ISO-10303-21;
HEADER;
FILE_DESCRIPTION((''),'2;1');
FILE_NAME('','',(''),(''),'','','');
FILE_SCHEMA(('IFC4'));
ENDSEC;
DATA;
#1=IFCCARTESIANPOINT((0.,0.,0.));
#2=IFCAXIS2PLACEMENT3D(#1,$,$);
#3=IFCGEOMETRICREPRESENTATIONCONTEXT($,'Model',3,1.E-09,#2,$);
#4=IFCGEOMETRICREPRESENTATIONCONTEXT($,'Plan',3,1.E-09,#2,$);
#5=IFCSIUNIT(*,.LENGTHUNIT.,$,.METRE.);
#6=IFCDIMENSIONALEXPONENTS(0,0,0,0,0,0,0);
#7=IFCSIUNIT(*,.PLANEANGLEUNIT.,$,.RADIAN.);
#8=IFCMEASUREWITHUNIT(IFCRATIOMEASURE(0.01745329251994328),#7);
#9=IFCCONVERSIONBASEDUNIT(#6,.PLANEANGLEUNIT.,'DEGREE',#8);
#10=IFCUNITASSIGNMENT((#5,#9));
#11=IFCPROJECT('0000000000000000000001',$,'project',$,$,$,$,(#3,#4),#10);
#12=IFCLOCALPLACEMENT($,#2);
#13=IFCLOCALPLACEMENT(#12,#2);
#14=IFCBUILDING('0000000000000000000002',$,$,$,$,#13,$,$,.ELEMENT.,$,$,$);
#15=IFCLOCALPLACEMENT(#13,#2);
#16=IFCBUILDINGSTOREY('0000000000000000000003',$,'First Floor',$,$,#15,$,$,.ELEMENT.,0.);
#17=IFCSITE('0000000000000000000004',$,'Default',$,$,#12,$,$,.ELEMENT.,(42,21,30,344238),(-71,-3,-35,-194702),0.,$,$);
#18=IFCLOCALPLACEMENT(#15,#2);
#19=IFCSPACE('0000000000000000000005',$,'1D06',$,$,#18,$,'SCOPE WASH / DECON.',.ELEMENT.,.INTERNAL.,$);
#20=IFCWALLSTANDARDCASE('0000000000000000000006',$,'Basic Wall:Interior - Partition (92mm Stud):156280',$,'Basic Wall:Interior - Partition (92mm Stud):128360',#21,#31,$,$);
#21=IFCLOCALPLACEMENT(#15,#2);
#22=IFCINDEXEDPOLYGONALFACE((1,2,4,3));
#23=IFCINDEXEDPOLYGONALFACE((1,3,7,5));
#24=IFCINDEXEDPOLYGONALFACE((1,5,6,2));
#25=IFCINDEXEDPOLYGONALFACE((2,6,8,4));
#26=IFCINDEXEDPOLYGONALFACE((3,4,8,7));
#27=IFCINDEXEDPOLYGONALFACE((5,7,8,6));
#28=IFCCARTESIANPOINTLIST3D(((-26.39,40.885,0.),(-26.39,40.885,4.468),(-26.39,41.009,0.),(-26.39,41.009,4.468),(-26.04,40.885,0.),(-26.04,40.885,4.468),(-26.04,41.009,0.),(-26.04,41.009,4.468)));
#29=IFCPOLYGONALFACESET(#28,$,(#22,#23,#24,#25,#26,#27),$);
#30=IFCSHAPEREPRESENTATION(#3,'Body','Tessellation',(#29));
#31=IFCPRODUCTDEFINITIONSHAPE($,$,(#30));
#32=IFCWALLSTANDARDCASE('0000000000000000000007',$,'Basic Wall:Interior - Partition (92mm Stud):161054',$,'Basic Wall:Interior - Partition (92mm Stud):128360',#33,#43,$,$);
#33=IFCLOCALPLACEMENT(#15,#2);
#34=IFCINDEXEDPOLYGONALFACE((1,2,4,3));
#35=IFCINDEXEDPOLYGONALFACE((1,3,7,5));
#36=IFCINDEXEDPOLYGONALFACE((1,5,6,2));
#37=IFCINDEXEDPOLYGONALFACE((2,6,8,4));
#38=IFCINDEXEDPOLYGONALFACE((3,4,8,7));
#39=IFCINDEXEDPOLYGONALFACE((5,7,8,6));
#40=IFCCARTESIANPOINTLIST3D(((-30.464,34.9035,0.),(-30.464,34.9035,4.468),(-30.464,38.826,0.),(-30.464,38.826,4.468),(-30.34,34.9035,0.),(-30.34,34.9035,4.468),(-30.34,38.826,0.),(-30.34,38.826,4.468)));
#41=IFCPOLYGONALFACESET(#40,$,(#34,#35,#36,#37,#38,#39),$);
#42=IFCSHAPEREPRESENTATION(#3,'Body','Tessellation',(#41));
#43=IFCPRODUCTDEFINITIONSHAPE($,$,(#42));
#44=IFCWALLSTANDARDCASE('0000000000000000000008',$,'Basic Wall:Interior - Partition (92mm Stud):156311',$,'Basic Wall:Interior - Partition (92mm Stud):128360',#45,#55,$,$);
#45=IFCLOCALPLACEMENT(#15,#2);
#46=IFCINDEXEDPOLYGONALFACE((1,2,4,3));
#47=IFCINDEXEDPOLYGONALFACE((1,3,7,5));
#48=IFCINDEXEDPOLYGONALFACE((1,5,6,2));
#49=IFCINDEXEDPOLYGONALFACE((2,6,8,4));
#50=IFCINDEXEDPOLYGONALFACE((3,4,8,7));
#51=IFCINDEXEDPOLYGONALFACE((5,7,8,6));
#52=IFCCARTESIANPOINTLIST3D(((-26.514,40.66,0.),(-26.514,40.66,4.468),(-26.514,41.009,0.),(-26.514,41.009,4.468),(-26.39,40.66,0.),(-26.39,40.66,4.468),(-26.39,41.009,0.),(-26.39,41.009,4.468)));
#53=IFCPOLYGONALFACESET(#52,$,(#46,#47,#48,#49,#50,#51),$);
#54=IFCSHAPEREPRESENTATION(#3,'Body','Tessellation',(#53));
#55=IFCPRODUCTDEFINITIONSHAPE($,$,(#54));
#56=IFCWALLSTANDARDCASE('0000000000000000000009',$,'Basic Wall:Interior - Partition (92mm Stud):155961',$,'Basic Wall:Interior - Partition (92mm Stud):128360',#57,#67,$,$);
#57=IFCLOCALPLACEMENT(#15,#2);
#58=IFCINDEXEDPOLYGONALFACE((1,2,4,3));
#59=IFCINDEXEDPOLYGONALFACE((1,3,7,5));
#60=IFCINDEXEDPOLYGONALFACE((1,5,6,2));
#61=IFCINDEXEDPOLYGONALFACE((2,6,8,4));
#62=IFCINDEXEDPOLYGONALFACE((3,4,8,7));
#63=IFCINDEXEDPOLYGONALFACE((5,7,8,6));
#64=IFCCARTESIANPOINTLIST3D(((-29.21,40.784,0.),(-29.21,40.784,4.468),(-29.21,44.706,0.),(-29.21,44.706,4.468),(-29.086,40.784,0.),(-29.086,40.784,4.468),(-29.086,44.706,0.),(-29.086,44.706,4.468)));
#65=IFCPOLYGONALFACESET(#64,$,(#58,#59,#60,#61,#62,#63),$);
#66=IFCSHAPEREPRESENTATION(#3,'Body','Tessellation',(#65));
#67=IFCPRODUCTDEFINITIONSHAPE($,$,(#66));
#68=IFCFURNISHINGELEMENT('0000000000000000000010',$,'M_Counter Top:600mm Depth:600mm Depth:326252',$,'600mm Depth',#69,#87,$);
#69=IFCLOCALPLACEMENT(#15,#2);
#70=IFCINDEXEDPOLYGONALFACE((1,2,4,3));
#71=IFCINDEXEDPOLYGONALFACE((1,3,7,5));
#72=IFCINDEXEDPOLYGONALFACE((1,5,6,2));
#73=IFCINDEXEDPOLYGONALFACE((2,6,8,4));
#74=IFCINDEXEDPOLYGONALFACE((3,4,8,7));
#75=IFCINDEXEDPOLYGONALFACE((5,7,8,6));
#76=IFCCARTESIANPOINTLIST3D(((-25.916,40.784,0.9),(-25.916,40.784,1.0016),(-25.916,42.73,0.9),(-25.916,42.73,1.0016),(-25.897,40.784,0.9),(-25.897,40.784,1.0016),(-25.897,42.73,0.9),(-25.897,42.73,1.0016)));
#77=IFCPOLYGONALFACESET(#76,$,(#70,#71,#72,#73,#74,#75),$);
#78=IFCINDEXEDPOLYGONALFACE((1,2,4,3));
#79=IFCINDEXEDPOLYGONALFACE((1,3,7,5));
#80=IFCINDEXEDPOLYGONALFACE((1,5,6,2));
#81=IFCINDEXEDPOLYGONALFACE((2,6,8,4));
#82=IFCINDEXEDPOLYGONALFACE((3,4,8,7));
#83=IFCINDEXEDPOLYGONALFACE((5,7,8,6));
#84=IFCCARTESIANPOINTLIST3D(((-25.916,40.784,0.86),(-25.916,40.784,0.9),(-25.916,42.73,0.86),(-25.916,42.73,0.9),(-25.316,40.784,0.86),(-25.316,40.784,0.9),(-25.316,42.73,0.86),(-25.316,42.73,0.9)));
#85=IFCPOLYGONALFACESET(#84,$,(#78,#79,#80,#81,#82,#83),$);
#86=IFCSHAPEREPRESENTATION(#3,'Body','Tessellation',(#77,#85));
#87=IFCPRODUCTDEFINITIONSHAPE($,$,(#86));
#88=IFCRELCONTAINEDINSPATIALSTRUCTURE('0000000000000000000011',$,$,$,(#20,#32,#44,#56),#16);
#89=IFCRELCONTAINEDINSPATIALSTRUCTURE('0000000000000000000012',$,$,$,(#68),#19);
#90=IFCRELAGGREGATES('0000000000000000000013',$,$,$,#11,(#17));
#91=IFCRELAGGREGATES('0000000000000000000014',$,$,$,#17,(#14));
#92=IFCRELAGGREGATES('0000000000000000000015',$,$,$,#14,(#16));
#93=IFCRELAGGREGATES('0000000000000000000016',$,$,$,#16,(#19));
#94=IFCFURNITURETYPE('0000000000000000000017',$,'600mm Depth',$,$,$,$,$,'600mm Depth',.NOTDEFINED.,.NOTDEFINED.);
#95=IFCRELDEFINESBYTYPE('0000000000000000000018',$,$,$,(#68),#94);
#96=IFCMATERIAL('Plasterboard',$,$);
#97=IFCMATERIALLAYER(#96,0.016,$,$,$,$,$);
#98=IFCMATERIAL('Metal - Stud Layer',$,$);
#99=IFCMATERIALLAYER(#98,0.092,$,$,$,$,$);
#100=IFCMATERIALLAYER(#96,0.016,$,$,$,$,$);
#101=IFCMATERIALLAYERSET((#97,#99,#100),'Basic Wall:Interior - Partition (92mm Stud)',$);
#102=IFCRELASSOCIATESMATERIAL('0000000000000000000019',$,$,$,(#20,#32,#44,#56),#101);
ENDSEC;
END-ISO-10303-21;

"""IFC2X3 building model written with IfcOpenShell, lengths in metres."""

from ifc_helpers import new_model, entity, si_unit, converted_unit, frame, frame_2d, origin, origin_2d_with_axis, place, context, project, spatial, rectangle, extrude, source, transform, mapped, material, layer, layer_set, layer_usage, type_object, type_shapes, element, save


model = new_model("IFC2X3")

# Units and contexts
model_context = context("Model", 3, precision=1e-09, world=origin())
plan_context = context("Plan", 3, precision=1e-09, world=origin())
ifc_project = project(units=[si_unit("LENGTHUNIT", "METRE"), converted_unit("PLANEANGLEUNIT", "DEGREE", entity("IfcRatioMeasure", 0.01745329251994328), si_unit("PLANEANGLEUNIT", "RADIAN"), dimensions=[0, 0, 0, 0, 0, 0, 0])], contexts=[model_context, plan_context])

# Site, building, storey
site_placement = place(None, origin())
site = spatial("IfcSite", under=ifc_project, at=site_placement, Name="Default", CompositionType="ELEMENT", RefLatitude=(42, 21, 30, 344238), RefLongitude=(-71, -3, -35, -194702), RefElevation=0.0)
building_placement = place(site_placement, origin())
building = spatial("IfcBuilding", under=site, at=building_placement, CompositionType="ELEMENT")
storey_placement = place(building_placement, origin())
storey = spatial("IfcBuildingStorey", under=building, at=storey_placement, Name="First Floor", CompositionType="ELEMENT", Elevation=0.0)

# Shared definitions
ifc_material_1 = material(Name="Plasterboard")
ifc_layer_1 = layer(ifc_material_1, 0.016)
ifc_material_2 = material(Name="Metal - Stud Layer")
ifc_layer_2 = layer(ifc_material_2, 0.092)
ifc_layer_3 = layer(ifc_material_1, 0.016)
ifc_layer_set_1 = layer_set([ifc_layer_1, ifc_layer_2, ifc_layer_3], Name="Basic Wall:Interior - Partition (92mm Stud)")
ifc_layer_usage_1 = layer_usage(ifc_layer_set_1, "AXIS2", "NEGATIVE", 0.062)

# Walls
wall_1_placement = place(storey_placement, frame((-26.04, 40.947, 0.0), z_axis=(0.0, 0.0, 1.0), x_axis=(-1.0, 0.0, 0.0)))
element("IfcWallStandardCase", 1, at=wall_1_placement, inside=storey, material=ifc_layer_usage_1, Name="Basic Wall:Interior - Partition (92mm Stud):156280", ObjectType="Basic Wall:Interior - Partition (92mm Stud):128360", context=model_context, shape_type="SweptSolid", body=[
    extrude(rectangle(XDim=0.35, YDim=0.124, at=frame_2d((0.175, 0.0), x_axis=(-1.0, 0.0))), origin(), (0.0, 0.0, 1.0), 4.468),
])
wall_2_placement = place(storey_placement, frame((-30.402, 38.826, 0.0), z_axis=(0.0, 0.0, 1.0), x_axis=(0.0, -1.0, 0.0)))
element("IfcWallStandardCase", 2, at=wall_2_placement, inside=storey, material=ifc_layer_usage_1, Name="Basic Wall:Interior - Partition (92mm Stud):161054", ObjectType="Basic Wall:Interior - Partition (92mm Stud):128360", context=model_context, shape_type="SweptSolid", body=[
    extrude(rectangle(XDim=3.9225, YDim=0.124, at=frame_2d((1.9612, 0.0), x_axis=(-1.0, 0.0))), origin(), (0.0, 0.0, 1.0), 4.468),
])
wall_3_placement = place(storey_placement, frame((-26.452, 41.009, 0.0), z_axis=(0.0, 0.0, 1.0), x_axis=(0.0, -1.0, 0.0)))
element("IfcWallStandardCase", 3, at=wall_3_placement, inside=storey, material=ifc_layer_usage_1, Name="Basic Wall:Interior - Partition (92mm Stud):156311", ObjectType="Basic Wall:Interior - Partition (92mm Stud):128360", context=model_context, shape_type="SweptSolid", body=[
    extrude(rectangle(XDim=0.349, YDim=0.124, at=frame_2d((0.1745, 0.0), x_axis=(-1.0, 0.0))), origin(), (0.0, 0.0, 1.0), 4.468),
])
wall_4_placement = place(storey_placement, frame((-29.148, 40.784, 0.0), z_axis=(0.0, 0.0, 1.0), x_axis=(0.0, 1.0, 0.0)))
element("IfcWallStandardCase", 4, at=wall_4_placement, inside=storey, material=ifc_layer_usage_1, Name="Basic Wall:Interior - Partition (92mm Stud):155961", ObjectType="Basic Wall:Interior - Partition (92mm Stud):128360", context=model_context, shape_type="SweptSolid", body=[
    extrude(rectangle(XDim=3.922, YDim=0.124, at=frame_2d((1.961, 0.0), x_axis=(-1.0, 0.0))), origin(), (0.0, 0.0, 1.0), 4.468),
])

# Shared definitions
space_1_placement = place(storey_placement, origin())
space_1 = spatial("IfcSpace", under=storey, at=space_1_placement, Name="1D06", LongName="SCOPE WASH / DECON.", CompositionType="ELEMENT", InteriorOrExteriorSpace="INTERNAL")

# Furnishing element
furniture_type_1 = type_object("IfcFurnitureType", Name="600mm Depth", ElementType="600mm Depth", AssemblyPlace="NOTDEFINED")
shared_shape_1 = source(origin(), model_context, "Body", "SweptSolid", [
    extrude(rectangle(XDim=0.0191, YDim=1.946, at=origin_2d_with_axis()), frame((-0.2275, -0.0095, 0.9), z_axis=(0.0, 0.0, 1.0), x_axis=(0.0, -1.0, 0.0)), (0.0, 0.0, 1.0), 0.1016),
    extrude(rectangle(XDim=1.946, YDim=0.6, at=origin_2d_with_axis()), frame((-0.2275, -0.3, 0.86), z_axis=(0.0, 0.0, 1.0), x_axis=(-1.0, 0.0, 0.0)), (0.0, 0.0, 1.0), 0.04),
])
type_shapes(furniture_type_1, [shared_shape_1])
furnishing_1_placement = place(space_1_placement, frame((-25.916, 41.9845, 0.0), z_axis=(0.0, 0.0, 1.0), x_axis=(0.0, 1.0, 0.0)))
element("IfcFurnishingElement", 5, at=furnishing_1_placement, inside=space_1, type_object=furniture_type_1, Name="M_Counter Top:600mm Depth:600mm Depth:326252", ObjectType="600mm Depth", context=model_context, shape_type="MappedRepresentation", body=[
    mapped(shared_shape_1, transform((0.0, 0.0, 0.0), scale=1.0)),
])

save(model, "model.ifc")
